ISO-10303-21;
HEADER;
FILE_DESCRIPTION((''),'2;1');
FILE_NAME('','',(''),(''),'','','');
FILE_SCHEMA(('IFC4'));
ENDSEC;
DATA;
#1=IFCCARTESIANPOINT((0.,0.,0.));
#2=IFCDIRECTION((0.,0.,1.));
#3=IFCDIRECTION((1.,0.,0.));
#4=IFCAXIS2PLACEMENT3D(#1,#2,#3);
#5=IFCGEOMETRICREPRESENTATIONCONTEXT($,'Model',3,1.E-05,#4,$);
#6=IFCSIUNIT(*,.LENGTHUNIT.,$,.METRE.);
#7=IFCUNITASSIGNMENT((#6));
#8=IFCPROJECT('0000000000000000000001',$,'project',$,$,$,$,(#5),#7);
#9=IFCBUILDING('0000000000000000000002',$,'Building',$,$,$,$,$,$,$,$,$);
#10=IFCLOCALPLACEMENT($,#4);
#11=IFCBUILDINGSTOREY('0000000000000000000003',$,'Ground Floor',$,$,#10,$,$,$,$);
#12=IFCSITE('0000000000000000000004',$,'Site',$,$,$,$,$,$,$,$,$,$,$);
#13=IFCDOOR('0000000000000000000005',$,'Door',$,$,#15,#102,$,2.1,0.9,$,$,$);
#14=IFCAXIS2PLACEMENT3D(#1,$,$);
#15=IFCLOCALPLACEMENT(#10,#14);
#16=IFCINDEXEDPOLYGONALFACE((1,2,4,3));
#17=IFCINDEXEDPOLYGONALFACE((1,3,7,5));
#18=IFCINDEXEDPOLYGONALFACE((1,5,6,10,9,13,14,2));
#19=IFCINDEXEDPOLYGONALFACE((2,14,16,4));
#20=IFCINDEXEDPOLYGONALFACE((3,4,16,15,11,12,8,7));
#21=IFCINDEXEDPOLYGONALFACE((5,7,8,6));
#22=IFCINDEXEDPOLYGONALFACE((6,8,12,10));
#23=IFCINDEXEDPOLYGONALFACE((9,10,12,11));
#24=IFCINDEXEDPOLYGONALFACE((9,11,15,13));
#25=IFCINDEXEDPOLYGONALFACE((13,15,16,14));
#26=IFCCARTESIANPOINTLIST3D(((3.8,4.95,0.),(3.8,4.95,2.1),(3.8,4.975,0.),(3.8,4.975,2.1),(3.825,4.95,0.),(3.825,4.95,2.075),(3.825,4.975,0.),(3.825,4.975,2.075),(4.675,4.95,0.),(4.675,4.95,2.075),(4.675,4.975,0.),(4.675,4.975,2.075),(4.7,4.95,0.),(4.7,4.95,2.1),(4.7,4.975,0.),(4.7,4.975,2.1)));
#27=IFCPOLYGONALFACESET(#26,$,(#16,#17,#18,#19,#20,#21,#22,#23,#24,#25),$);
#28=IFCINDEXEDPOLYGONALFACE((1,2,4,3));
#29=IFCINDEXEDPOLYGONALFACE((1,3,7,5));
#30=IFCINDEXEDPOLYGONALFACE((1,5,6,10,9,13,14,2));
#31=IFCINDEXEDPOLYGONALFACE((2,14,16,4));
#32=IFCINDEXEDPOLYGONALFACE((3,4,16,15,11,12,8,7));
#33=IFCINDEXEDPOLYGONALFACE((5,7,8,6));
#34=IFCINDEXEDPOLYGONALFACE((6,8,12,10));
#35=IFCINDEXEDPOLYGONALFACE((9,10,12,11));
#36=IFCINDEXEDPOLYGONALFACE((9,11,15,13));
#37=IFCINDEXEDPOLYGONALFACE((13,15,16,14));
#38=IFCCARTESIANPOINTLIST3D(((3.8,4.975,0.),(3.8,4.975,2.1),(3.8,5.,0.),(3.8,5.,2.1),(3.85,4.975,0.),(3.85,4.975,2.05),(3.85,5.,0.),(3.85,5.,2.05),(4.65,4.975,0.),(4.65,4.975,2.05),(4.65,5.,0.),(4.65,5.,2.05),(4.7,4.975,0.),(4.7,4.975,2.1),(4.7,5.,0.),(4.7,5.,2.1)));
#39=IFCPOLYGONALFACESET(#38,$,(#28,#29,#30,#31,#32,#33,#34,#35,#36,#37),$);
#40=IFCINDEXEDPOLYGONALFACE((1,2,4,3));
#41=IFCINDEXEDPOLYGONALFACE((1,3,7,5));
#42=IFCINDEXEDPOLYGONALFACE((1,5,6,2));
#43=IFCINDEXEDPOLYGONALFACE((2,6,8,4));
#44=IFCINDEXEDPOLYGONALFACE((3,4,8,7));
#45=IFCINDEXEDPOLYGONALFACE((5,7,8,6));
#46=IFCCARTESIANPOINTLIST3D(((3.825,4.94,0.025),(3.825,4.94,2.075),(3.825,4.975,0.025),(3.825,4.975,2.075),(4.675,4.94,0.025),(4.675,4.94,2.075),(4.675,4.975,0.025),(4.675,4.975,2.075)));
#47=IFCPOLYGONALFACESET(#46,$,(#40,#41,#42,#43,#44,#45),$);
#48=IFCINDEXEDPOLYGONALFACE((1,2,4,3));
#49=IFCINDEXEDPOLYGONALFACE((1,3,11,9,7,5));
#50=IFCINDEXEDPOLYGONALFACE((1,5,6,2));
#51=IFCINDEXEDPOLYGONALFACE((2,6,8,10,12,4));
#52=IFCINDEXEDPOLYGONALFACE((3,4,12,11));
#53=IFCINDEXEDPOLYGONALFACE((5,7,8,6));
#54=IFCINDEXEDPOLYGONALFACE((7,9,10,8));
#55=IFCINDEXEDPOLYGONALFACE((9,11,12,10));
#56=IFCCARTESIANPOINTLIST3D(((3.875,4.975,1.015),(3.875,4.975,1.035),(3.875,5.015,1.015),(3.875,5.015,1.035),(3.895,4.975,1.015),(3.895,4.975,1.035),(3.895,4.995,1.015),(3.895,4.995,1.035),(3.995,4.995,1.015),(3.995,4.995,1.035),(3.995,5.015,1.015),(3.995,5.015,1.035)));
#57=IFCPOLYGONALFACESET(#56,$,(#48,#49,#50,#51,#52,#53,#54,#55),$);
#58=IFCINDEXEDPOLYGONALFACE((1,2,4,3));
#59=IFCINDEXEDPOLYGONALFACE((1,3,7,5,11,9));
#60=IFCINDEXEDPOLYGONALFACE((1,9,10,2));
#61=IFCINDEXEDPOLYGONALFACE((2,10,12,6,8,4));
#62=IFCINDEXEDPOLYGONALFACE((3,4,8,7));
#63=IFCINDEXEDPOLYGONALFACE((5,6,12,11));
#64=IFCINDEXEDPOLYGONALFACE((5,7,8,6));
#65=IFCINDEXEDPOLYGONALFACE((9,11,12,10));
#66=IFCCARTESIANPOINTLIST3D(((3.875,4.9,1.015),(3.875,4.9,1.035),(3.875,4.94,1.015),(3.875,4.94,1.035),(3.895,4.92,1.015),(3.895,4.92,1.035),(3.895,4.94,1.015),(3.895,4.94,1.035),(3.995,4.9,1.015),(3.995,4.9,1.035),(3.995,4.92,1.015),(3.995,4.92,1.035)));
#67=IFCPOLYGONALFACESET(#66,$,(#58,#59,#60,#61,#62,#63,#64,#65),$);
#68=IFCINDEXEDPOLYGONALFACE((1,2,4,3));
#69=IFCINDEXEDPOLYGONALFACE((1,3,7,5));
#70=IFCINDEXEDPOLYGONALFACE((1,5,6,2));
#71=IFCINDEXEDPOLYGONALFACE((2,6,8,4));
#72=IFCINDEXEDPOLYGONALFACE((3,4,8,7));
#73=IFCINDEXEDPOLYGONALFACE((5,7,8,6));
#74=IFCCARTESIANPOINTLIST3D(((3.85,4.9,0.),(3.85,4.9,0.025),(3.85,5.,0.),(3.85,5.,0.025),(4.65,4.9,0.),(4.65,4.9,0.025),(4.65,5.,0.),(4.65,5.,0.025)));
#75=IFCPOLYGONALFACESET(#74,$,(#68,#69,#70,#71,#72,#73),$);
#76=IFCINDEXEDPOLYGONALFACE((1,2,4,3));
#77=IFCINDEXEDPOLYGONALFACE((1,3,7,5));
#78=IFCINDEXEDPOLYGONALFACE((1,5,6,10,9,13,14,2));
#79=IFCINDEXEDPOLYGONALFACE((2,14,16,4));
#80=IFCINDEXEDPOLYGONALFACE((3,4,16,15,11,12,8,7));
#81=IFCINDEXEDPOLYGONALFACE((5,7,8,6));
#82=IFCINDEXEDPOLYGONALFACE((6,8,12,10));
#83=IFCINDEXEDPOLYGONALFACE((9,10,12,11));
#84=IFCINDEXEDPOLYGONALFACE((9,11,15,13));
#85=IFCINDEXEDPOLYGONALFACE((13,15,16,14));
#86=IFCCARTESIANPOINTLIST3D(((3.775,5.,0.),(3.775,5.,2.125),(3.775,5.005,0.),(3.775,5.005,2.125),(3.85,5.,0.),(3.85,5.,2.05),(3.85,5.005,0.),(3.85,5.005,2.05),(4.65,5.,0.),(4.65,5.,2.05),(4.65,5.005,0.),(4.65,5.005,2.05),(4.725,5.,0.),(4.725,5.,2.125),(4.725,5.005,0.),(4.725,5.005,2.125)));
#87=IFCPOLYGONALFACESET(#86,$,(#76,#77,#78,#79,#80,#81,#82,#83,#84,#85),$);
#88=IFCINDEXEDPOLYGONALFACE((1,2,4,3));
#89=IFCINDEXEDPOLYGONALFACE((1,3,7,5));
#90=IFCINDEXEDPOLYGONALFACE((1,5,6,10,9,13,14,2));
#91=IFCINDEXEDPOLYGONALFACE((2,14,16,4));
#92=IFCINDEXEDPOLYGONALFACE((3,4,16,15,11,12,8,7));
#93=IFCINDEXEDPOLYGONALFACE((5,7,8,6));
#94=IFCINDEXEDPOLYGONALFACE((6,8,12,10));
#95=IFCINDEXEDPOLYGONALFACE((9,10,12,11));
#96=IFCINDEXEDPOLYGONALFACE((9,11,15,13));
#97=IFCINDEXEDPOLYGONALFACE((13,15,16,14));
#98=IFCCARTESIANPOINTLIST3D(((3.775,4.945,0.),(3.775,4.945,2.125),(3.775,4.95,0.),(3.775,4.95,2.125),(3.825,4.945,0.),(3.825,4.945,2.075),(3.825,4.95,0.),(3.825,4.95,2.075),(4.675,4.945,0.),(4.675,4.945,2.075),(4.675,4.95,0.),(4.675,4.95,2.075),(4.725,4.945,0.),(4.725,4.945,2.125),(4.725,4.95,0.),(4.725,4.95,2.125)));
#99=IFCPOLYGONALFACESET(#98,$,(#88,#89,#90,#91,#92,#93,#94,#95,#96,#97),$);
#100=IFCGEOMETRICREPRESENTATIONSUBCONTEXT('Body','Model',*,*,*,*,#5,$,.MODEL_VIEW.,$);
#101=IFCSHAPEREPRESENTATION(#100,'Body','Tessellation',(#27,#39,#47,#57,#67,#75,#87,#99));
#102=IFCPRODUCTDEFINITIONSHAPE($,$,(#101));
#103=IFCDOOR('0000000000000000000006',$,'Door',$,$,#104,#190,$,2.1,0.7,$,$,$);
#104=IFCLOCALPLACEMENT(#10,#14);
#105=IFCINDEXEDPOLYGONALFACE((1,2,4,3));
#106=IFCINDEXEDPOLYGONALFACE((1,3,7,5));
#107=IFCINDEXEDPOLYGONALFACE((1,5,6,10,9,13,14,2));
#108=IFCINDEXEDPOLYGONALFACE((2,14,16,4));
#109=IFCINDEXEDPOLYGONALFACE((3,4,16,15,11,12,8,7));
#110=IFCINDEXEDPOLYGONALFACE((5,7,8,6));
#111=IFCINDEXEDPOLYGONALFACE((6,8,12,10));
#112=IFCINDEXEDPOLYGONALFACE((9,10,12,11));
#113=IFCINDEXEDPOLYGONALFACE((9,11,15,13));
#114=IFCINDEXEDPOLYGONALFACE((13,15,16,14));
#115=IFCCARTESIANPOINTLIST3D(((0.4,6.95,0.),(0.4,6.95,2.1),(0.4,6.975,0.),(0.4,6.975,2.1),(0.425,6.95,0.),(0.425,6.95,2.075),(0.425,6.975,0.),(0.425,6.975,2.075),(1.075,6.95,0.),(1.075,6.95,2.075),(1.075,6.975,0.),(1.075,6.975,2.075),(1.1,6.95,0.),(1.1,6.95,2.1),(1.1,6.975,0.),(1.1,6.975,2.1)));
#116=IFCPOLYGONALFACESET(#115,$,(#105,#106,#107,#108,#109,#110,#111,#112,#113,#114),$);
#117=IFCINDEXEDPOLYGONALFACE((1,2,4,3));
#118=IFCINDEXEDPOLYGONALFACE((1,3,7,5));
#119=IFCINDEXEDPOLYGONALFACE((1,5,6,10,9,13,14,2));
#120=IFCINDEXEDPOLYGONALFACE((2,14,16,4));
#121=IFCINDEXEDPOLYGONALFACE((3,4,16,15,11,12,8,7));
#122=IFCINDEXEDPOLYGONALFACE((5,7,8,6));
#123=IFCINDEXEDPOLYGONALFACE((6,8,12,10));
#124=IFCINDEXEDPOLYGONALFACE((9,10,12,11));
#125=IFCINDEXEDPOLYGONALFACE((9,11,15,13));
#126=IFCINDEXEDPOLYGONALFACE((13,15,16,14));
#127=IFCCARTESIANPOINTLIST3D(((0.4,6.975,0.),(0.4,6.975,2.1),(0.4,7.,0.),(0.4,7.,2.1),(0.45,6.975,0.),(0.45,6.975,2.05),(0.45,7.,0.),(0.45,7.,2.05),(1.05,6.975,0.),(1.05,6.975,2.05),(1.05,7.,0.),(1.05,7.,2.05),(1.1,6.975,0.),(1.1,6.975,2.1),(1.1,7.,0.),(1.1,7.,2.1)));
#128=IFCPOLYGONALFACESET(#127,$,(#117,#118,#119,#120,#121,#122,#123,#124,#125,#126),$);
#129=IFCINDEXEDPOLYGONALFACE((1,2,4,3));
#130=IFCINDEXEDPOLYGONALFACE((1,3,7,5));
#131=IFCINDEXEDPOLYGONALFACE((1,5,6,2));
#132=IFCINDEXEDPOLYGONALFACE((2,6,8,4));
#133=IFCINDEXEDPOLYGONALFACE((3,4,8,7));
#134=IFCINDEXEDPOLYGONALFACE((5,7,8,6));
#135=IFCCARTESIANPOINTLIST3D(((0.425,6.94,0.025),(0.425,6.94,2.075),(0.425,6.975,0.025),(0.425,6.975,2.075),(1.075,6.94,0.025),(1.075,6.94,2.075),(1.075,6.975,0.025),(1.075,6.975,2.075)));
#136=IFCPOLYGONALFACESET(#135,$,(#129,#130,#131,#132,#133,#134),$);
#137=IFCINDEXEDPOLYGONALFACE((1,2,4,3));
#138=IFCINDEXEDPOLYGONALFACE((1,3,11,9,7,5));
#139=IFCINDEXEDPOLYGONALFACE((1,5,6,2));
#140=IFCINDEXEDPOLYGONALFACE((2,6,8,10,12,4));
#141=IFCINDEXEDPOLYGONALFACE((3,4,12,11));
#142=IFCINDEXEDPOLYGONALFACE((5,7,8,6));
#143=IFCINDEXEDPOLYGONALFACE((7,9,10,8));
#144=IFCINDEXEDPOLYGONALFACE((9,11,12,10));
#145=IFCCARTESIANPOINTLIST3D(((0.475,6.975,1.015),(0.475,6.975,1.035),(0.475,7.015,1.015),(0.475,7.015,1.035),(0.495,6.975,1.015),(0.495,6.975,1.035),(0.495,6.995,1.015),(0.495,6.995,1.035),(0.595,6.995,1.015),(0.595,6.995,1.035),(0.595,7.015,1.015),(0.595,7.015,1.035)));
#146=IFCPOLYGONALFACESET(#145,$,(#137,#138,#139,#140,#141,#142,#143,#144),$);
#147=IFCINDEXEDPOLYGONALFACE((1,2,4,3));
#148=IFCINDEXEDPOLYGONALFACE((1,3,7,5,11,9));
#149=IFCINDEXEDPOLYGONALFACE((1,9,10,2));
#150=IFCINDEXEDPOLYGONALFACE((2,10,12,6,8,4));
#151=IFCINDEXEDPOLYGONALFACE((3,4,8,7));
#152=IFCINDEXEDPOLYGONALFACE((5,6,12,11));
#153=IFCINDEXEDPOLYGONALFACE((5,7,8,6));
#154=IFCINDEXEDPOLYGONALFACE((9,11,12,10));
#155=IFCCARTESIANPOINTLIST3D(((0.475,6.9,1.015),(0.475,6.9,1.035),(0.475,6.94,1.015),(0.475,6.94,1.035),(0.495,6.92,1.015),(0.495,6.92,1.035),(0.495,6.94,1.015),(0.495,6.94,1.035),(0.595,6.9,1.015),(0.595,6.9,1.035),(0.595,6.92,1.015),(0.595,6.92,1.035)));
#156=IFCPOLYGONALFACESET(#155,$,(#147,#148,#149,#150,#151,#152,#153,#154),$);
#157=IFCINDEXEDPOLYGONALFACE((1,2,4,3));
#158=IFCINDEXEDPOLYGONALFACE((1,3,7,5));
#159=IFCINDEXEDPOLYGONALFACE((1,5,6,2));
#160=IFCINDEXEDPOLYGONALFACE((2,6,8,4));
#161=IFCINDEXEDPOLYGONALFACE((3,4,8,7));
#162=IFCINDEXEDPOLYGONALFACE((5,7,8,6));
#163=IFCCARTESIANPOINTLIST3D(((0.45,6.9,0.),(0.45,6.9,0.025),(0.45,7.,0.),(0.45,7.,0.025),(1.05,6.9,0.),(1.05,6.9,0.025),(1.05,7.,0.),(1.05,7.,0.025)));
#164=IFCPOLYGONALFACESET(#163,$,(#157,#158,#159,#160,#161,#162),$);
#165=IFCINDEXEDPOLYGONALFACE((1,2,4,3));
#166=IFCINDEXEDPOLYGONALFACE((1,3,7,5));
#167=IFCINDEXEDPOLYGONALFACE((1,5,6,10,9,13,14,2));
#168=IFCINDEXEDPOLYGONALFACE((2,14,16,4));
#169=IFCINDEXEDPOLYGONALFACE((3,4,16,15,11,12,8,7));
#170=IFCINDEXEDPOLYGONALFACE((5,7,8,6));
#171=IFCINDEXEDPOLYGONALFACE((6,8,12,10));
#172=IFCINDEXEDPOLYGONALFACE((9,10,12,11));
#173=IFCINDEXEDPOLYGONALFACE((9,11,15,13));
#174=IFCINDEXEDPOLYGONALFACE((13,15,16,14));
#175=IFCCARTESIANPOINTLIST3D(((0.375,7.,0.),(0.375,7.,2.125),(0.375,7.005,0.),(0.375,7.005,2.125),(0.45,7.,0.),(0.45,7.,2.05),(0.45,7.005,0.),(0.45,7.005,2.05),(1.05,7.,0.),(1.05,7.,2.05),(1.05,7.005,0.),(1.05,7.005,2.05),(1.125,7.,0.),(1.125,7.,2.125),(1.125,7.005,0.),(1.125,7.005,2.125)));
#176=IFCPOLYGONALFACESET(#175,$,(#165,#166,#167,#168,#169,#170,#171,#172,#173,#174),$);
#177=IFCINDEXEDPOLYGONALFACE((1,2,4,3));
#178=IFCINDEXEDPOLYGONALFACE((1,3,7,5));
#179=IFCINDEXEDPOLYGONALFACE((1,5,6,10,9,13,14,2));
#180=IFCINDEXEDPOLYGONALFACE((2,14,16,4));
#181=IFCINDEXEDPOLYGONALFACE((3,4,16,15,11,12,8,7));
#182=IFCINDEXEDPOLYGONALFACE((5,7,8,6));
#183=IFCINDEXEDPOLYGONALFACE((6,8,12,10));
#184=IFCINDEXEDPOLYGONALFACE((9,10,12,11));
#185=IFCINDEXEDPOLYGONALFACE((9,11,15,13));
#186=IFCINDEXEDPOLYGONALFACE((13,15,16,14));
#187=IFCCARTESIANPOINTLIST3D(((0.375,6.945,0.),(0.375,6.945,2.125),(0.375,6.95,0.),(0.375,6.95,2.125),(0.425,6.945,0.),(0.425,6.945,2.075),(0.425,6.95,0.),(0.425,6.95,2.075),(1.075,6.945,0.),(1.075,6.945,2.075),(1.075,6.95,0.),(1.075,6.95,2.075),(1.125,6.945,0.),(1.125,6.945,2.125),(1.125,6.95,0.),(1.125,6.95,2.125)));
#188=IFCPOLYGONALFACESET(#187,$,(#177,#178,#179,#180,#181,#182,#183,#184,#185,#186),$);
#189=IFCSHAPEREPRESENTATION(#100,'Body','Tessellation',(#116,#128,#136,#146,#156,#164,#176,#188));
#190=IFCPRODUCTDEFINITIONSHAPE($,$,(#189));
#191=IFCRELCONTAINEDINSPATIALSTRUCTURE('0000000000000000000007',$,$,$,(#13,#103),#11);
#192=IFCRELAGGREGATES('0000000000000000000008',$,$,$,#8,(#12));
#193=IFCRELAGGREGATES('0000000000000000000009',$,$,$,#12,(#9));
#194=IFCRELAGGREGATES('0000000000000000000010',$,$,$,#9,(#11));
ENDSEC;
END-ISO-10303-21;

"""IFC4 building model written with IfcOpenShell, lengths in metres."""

from ifc_helpers import new_model, si_unit, frame, origin_with_axes, place, context, subcontext, project, spatial, line, indexed_curve, outline, extrude, element, save


model = new_model("IFC4")

# Units and contexts
model_context = context("Model", 3, precision=1e-05, world=origin_with_axes())
body_context = subcontext(model_context, "Body", "Model", "MODEL_VIEW")
ifc_project = project(units=[si_unit("LENGTHUNIT", "METRE")], contexts=[model_context])

# Site, building, storey
site = spatial("IfcSite", under=ifc_project, Name="Site")
building = spatial("IfcBuilding", under=site, Name="Building")
storey_placement = place(None, origin_with_axes())
storey = spatial("IfcBuildingStorey", under=building, at=storey_placement, Name="Ground Floor")

# Doors
door_1_placement = place(storey_placement, frame((4.7, 5.0, 0.0), z_axis=(0.0, 0.0, 1.0), x_axis=(-1.0, 0.0, 0.0)))
element("IfcDoor", 1, at=door_1_placement, inside=storey, Name="Door", OverallHeight=2.1, OverallWidth=0.9, context=body_context, shape_type="SweptSolid", body=[
    extrude(outline(indexed_curve([(0.0, 0.0), (0.0, 2.1), (0.9, 2.1), (0.9, 0.0), (0.875, 0.0), (0.875, 2.075), (0.025, 2.075), (0.025, 0.0)], segments=[line(1, 2, 3, 4, 5, 6, 7, 8, 1)])), frame((0.0, 0.025, 0.0), z_axis=(0.0, -1.0, 0.0), x_axis=(1.0, 0.0, 0.0)), (0.0, 0.0, -1.0), 0.025),
    extrude(outline(indexed_curve([(0.0, 0.0), (0.0, 2.1), (0.9, 2.1), (0.9, 0.0), (0.85, 0.0), (0.85, 2.05), (0.05, 2.05), (0.05, 0.0)], segments=[line(1, 2, 3, 4, 5, 6, 7, 8, 1)])), frame((0.0, 0.0, 0.0), z_axis=(0.0, -1.0, 0.0), x_axis=(1.0, 0.0, 0.0)), (0.0, 0.0, -1.0), 0.025),
    extrude(outline(indexed_curve([(0.0, 0.0), (0.85, 0.0), (0.85, 0.035), (0.0, 0.035)], segments=[line(1, 2, 3, 4, 1)])), frame((0.025, 0.025, 0.025), z_axis=(0.0, 0.0, 1.0), x_axis=(1.0, 0.0, 0.0)), (0.0, 0.0, 1.0), 2.05),
    extrude(outline(indexed_curve([(0.0, 0.0), (0.0, -0.04), (-0.12, -0.04), (-0.12, -0.02), (-0.02, -0.02), (-0.02, 0.0)], segments=[line(1, 2, 3, 4, 5, 6, 1)])), frame((0.825, 0.025, 1.015), z_axis=(0.0, 0.0, 1.0), x_axis=(1.0, 0.0, 0.0)), (0.0, 0.0, 1.0), 0.02),
    extrude(outline(indexed_curve([(0.0, 0.0), (0.0, 0.04), (-0.12, 0.04), (-0.12, 0.02), (-0.02, 0.02), (-0.02, 0.0)], segments=[line(1, 2, 3, 4, 5, 6, 1)])), frame((0.825, 0.06, 1.015), z_axis=(0.0, 0.0, 1.0), x_axis=(1.0, 0.0, 0.0)), (0.0, 0.0, 1.0), 0.02),
    extrude(outline(indexed_curve([(0.0, 0.0), (0.8, 0.0), (0.8, 0.1), (0.0, 0.1)], segments=[line(1, 2, 3, 4, 1)])), frame((0.05, 0.0, 0.0), z_axis=(0.0, 0.0, 1.0), x_axis=(1.0, 0.0, 0.0)), (0.0, 0.0, 1.0), 0.025),
    extrude(outline(indexed_curve([(0.0, 0.0), (0.0, 2.125), (0.95, 2.125), (0.95, 0.0), (0.875, 0.0), (0.875, 2.05), (0.075, 2.05), (0.075, 0.0)], segments=[line(1, 2, 3, 4, 5, 6, 7, 8, 1)])), frame((-0.025, -0.005, 0.0), z_axis=(0.0, -1.0, 0.0), x_axis=(1.0, 0.0, 0.0)), (0.0, 0.0, -1.0), 0.005),
    extrude(outline(indexed_curve([(0.0, 0.0), (0.0, 2.125), (0.95, 2.125), (0.95, 0.0), (0.9, 0.0), (0.9, 2.075), (0.05, 2.075), (0.05, 0.0)], segments=[line(1, 2, 3, 4, 5, 6, 7, 8, 1)])), frame((-0.025, 0.05, 0.0), z_axis=(0.0, -1.0, 0.0), x_axis=(1.0, 0.0, 0.0)), (0.0, 0.0, -1.0), 0.005),
])
door_2_placement = place(storey_placement, frame((1.1, 7.0, 0.0), z_axis=(0.0, 0.0, 1.0), x_axis=(-1.0, 0.0, 0.0)))
element("IfcDoor", 2, at=door_2_placement, inside=storey, Name="Door", OverallHeight=2.1, OverallWidth=0.7, context=body_context, shape_type="SweptSolid", body=[
    extrude(outline(indexed_curve([(0.0, 0.0), (0.0, 2.1), (0.7, 2.1), (0.7, 0.0), (0.675, 0.0), (0.675, 2.075), (0.025, 2.075), (0.025, 0.0)], segments=[line(1, 2, 3, 4, 5, 6, 7, 8, 1)])), frame((0.0, 0.025, 0.0), z_axis=(0.0, -1.0, 0.0), x_axis=(1.0, 0.0, 0.0)), (0.0, 0.0, -1.0), 0.025),
    extrude(outline(indexed_curve([(0.0, 0.0), (0.0, 2.1), (0.7, 2.1), (0.7, 0.0), (0.65, 0.0), (0.65, 2.05), (0.05, 2.05), (0.05, 0.0)], segments=[line(1, 2, 3, 4, 5, 6, 7, 8, 1)])), frame((0.0, 0.0, 0.0), z_axis=(0.0, -1.0, 0.0), x_axis=(1.0, 0.0, 0.0)), (0.0, 0.0, -1.0), 0.025),
    extrude(outline(indexed_curve([(0.0, 0.0), (0.65, 0.0), (0.65, 0.035), (0.0, 0.035)], segments=[line(1, 2, 3, 4, 1)])), frame((0.025, 0.025, 0.025), z_axis=(0.0, 0.0, 1.0), x_axis=(1.0, 0.0, 0.0)), (0.0, 0.0, 1.0), 2.05),
    extrude(outline(indexed_curve([(0.0, 0.0), (0.0, -0.04), (-0.12, -0.04), (-0.12, -0.02), (-0.02, -0.02), (-0.02, 0.0)], segments=[line(1, 2, 3, 4, 5, 6, 1)])), frame((0.625, 0.025, 1.015), z_axis=(0.0, 0.0, 1.0), x_axis=(1.0, 0.0, 0.0)), (0.0, 0.0, 1.0), 0.02),
    extrude(outline(indexed_curve([(0.0, 0.0), (0.0, 0.04), (-0.12, 0.04), (-0.12, 0.02), (-0.02, 0.02), (-0.02, 0.0)], segments=[line(1, 2, 3, 4, 5, 6, 1)])), frame((0.625, 0.06, 1.015), z_axis=(0.0, 0.0, 1.0), x_axis=(1.0, 0.0, 0.0)), (0.0, 0.0, 1.0), 0.02),
    extrude(outline(indexed_curve([(0.0, 0.0), (0.6, 0.0), (0.6, 0.1), (0.0, 0.1)], segments=[line(1, 2, 3, 4, 1)])), frame((0.05, 0.0, 0.0), z_axis=(0.0, 0.0, 1.0), x_axis=(1.0, 0.0, 0.0)), (0.0, 0.0, 1.0), 0.025),
    extrude(outline(indexed_curve([(0.0, 0.0), (0.0, 2.125), (0.75, 2.125), (0.75, 0.0), (0.675, 0.0), (0.675, 2.05), (0.075, 2.05), (0.075, 0.0)], segments=[line(1, 2, 3, 4, 5, 6, 7, 8, 1)])), frame((-0.025, -0.005, 0.0), z_axis=(0.0, -1.0, 0.0), x_axis=(1.0, 0.0, 0.0)), (0.0, 0.0, -1.0), 0.005),
    extrude(outline(indexed_curve([(0.0, 0.0), (0.0, 2.125), (0.75, 2.125), (0.75, 0.0), (0.7, 0.0), (0.7, 2.075), (0.05, 2.075), (0.05, 0.0)], segments=[line(1, 2, 3, 4, 5, 6, 7, 8, 1)])), frame((-0.025, 0.05, 0.0), z_axis=(0.0, -1.0, 0.0), x_axis=(1.0, 0.0, 0.0)), (0.0, 0.0, -1.0), 0.005),
])

save(model, "model.ifc")
